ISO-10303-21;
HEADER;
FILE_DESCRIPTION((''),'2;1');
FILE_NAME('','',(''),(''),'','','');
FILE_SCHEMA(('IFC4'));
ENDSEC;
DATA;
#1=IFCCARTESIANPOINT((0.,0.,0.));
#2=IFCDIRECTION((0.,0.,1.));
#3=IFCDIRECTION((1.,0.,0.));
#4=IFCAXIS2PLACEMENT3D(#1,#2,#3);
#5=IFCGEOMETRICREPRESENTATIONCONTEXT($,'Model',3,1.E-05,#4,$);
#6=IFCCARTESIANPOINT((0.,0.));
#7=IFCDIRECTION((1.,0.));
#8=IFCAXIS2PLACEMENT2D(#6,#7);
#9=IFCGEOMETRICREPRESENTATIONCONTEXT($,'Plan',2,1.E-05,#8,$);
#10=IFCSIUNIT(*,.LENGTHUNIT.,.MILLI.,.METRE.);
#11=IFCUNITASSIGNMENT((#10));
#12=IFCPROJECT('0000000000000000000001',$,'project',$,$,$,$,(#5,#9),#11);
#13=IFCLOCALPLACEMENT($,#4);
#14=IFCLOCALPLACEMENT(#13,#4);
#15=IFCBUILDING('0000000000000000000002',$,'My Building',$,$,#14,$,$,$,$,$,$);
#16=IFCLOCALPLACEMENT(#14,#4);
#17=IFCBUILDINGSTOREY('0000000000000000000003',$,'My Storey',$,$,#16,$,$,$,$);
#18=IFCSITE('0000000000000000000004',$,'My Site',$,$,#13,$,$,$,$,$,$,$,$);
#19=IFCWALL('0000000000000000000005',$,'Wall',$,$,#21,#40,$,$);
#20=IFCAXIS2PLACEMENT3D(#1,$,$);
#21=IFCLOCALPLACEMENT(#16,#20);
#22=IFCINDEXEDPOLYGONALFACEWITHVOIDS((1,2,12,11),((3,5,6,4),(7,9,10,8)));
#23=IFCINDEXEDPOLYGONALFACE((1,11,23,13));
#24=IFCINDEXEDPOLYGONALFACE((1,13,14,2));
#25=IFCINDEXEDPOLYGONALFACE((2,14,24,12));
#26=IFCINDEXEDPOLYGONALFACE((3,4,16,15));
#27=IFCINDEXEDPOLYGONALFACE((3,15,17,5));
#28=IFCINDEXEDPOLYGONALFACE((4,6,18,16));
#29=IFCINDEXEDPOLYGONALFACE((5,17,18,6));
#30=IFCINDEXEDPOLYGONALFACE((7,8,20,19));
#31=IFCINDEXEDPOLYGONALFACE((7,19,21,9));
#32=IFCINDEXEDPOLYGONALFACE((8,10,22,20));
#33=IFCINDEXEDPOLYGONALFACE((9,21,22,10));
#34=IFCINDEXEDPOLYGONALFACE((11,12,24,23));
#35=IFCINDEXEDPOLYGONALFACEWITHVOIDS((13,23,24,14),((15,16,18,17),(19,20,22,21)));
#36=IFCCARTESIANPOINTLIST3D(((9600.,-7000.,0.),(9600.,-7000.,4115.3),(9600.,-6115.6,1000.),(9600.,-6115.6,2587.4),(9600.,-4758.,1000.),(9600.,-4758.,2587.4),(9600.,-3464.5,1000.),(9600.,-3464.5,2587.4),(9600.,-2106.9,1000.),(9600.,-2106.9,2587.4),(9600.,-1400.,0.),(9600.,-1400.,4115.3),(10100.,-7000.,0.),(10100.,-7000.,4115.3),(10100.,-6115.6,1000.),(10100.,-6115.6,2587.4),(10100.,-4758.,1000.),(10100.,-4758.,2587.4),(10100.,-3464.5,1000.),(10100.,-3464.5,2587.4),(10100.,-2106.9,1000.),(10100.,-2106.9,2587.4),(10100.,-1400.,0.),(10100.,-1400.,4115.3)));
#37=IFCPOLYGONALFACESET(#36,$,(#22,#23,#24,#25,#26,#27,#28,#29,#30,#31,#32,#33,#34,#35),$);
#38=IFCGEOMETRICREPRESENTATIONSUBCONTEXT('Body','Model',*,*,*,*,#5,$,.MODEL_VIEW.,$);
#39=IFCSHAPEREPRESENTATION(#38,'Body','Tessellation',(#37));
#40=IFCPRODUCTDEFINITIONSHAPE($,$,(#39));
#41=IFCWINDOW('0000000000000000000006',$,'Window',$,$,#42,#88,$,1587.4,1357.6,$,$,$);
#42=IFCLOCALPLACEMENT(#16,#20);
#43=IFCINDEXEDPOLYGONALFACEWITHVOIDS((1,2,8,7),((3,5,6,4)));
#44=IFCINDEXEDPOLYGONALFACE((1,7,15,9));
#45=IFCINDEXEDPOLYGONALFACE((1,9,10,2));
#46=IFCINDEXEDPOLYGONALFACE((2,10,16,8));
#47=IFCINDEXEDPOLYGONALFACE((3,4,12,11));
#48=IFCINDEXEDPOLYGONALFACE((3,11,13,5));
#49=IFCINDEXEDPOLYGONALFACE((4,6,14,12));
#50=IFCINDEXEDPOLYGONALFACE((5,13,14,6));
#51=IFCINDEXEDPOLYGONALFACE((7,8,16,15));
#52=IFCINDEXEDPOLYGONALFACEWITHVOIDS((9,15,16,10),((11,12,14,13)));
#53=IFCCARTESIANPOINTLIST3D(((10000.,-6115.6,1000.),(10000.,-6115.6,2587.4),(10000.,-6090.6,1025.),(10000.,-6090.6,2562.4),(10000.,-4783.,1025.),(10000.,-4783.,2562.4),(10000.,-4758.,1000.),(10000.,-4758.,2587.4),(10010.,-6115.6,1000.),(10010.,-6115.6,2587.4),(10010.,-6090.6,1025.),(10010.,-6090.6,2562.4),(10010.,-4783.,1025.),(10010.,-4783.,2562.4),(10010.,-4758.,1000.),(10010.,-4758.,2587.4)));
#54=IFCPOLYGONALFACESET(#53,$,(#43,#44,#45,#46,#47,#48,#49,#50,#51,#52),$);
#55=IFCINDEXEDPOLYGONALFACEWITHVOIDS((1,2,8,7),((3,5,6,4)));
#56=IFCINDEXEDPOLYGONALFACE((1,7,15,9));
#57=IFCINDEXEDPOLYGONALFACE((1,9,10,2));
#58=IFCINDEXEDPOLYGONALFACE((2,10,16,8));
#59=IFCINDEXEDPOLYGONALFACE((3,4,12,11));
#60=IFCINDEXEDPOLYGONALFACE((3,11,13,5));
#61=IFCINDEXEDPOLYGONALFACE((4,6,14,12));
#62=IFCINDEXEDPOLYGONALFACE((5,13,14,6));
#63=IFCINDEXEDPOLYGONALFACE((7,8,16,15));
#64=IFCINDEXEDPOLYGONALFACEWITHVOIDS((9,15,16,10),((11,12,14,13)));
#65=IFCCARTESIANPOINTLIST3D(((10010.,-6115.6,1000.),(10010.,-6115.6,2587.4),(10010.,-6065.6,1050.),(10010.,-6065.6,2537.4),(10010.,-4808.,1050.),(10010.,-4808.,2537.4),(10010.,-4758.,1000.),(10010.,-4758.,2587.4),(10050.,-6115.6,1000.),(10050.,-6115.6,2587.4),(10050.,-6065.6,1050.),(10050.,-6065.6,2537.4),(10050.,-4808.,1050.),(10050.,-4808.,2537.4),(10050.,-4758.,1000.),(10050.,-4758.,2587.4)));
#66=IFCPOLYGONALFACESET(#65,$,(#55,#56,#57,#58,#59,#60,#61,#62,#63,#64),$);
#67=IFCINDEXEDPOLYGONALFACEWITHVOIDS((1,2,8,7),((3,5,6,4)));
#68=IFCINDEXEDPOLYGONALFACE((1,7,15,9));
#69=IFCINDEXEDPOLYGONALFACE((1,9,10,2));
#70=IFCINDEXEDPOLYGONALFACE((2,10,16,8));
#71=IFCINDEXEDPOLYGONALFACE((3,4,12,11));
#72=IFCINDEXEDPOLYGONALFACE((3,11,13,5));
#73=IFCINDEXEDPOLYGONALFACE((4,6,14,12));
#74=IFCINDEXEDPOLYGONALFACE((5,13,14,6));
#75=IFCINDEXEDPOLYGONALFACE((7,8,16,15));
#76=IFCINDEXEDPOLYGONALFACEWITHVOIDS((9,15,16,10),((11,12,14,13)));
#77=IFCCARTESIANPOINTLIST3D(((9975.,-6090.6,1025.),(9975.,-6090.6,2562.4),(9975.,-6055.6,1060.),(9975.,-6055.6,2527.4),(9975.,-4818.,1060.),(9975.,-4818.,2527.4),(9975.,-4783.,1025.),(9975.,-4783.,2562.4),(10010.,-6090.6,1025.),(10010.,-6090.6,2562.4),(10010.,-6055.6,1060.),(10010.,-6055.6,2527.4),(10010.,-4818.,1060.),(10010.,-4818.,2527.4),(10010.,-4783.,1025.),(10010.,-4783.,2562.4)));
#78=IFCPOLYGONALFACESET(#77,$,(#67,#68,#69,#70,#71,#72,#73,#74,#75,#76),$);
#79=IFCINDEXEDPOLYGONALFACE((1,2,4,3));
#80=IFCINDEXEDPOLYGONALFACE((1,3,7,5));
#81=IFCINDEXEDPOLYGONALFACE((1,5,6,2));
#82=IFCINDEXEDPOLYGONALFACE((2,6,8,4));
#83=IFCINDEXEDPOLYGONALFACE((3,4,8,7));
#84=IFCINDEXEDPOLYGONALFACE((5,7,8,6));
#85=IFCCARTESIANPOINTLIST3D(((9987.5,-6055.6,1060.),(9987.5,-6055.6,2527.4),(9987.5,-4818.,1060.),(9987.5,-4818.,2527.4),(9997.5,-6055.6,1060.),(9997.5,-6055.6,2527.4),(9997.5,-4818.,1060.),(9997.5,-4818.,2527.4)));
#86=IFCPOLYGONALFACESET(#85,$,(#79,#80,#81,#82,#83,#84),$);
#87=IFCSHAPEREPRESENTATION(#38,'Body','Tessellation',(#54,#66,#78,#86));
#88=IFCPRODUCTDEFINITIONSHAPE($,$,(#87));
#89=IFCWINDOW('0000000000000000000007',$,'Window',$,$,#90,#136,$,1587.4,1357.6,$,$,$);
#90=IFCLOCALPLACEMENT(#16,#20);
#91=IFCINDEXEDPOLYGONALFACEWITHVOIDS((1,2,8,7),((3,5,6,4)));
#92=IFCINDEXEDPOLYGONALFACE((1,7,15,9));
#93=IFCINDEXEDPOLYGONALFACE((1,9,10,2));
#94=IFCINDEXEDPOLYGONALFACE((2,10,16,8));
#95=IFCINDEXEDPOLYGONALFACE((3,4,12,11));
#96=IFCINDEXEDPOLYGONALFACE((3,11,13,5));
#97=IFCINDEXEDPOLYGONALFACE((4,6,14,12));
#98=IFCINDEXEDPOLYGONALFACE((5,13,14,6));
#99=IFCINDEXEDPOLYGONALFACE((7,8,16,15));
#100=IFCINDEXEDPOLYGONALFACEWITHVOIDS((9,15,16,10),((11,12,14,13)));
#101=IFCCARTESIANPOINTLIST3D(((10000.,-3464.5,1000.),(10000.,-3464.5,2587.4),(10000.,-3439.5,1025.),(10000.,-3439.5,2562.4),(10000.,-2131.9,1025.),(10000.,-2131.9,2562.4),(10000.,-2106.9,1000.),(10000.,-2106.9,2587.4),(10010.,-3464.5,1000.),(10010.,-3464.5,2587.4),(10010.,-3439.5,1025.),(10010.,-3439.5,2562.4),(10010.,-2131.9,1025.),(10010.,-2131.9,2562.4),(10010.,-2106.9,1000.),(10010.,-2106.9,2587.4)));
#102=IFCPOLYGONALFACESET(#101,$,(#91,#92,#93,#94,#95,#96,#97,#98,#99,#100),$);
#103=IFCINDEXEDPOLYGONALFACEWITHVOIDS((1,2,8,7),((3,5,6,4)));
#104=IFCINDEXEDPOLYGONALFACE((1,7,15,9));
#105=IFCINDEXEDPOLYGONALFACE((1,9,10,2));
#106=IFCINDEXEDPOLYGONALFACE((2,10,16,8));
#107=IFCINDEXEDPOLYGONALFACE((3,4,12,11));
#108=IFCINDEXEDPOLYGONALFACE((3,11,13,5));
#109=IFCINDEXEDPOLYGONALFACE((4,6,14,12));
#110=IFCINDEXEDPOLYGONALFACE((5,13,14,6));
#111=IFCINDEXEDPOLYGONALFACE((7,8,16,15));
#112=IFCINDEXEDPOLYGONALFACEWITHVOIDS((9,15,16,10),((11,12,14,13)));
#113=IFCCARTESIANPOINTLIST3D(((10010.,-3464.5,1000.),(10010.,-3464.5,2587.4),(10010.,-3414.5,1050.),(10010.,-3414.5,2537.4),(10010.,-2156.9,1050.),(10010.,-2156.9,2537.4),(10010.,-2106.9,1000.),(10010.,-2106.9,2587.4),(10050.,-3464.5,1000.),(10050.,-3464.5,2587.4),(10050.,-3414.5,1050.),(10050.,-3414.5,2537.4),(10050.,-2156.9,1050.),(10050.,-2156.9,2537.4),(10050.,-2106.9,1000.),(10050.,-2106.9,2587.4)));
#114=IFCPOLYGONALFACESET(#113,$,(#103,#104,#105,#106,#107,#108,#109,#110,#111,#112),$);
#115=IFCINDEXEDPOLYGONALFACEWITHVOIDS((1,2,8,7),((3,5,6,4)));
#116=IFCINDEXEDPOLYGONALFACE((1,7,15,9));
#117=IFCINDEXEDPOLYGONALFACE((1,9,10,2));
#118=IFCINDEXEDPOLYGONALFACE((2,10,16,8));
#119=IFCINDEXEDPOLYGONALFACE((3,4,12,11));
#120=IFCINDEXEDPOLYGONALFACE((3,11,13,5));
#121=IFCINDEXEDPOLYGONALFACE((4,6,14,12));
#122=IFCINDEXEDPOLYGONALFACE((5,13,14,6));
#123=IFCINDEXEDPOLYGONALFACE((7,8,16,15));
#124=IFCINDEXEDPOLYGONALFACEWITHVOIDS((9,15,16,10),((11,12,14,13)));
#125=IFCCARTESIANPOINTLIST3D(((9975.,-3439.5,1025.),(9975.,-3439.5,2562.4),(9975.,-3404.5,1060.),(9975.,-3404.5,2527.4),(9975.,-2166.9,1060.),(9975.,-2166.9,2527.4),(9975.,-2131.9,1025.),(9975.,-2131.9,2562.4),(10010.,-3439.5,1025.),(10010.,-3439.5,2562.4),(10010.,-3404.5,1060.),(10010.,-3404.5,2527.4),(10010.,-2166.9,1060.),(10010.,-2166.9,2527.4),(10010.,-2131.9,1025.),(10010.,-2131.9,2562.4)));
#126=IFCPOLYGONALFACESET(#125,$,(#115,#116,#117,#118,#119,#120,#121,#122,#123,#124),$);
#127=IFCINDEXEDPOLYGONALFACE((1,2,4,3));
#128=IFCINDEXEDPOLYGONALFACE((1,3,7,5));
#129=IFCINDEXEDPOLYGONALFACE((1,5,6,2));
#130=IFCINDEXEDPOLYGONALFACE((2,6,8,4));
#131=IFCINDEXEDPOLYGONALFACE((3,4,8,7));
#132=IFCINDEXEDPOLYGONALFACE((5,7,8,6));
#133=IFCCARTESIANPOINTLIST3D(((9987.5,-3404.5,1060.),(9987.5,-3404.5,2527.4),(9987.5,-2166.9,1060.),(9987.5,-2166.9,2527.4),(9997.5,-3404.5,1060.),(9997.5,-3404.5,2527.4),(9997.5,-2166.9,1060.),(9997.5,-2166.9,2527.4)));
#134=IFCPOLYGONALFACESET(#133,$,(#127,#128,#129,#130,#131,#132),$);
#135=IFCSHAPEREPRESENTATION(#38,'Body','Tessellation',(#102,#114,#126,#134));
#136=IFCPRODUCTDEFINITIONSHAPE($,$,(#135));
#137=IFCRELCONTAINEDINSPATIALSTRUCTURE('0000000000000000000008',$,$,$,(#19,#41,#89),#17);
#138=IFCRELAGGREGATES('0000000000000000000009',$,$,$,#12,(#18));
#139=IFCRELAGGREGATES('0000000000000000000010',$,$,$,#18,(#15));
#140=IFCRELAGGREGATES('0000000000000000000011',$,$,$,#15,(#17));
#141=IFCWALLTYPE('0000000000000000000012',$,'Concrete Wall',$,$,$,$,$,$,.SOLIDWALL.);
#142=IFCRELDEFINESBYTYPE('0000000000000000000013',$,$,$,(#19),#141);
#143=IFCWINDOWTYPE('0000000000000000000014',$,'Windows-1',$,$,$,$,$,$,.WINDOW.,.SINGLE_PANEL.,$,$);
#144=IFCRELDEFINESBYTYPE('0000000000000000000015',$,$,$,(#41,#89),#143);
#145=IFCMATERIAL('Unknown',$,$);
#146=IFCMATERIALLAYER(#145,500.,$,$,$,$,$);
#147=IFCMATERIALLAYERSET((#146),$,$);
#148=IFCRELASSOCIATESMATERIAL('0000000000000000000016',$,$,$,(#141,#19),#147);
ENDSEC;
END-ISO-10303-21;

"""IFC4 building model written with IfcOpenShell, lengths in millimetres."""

from ifc_helpers import new_model, entity, si_unit, frame, origin_with_axes, origin_2d_with_axis, place, context, subcontext, project, spatial, line, indexed_curve, outline, extrude, shape, source, transform, mapped, material, layer, layer_set, layer_usage, type_object, type_shapes, element, fill, save


model = new_model("IFC4")

# Units and contexts
model_context = context("Model", 3, precision=1e-05, world=origin_with_axes())
plan_context = context("Plan", 2, precision=1e-05, world=origin_2d_with_axis())
body_context_1 = subcontext(model_context, "Body", "Model", "MODEL_VIEW")
body_context_2 = subcontext(plan_context, "Body", "Plan", "PLAN_VIEW")
ifc_project = project(units=[si_unit("LENGTHUNIT", "METRE", prefix="MILLI")], contexts=[model_context, plan_context])

# Site, building, storey
site_placement = place(None, origin_with_axes())
site = spatial("IfcSite", under=ifc_project, at=site_placement, Name="My Site")
building_placement = place(site_placement, origin_with_axes())
building = spatial("IfcBuilding", under=site, at=building_placement, Name="My Building")
storey_placement = place(building_placement, origin_with_axes())
storey = spatial("IfcBuildingStorey", under=building, at=storey_placement, Name="My Storey")

# Shared definitions
ifc_material = material(Name="Unknown")

# Wall, openings, windows
ifc_layer_1 = layer(ifc_material, 500.0)
ifc_layer_set_1 = layer_set([ifc_layer_1])
wall_type = type_object("IfcWallType", Name="Concrete Wall", PredefinedType="SOLIDWALL", material=ifc_layer_set_1)
shared_shape_1 = source(origin_with_axes(), body_context_1, "Body", "SweptSolid", [
    extrude(outline(indexed_curve([(0.0, 0.0), (1357.6, 0.0), (1357.6, 1587.4), (0.0, 1587.4)], segments=[line(1, 2, 3, 4, 1)])), frame((0.0, -600.0, 0.0), z_axis=(0.0, -1.0, 0.0), x_axis=(1.0, 0.0, 0.0)), (0.0, 0.0, -1.0), 1200.0),
])
window_type = type_object("IfcWindowType", Name="Windows-1", PartitioningType="SINGLE_PANEL", PredefinedType="WINDOW")
shared_shape_2 = source(origin_with_axes(), body_context_1, "Body", "SweptSolid", [
    extrude(outline(indexed_curve([(0.0, 0.0), (1357.6, 0.0), (1357.6, 1587.4), (0.0, 1587.4)], segments=[line(1, 2, 3, 4, 1)]), holes=[indexed_curve([(25.0, 25.0), (1332.6, 25.0), (1332.6, 1562.4), (25.0, 1562.4)], segments=[line(1, 2, 3, 4, 1)])]), frame((0.0, 90.0, 0.0), z_axis=(0.0, -1.0, 0.0), x_axis=(1.0, 0.0, 0.0)), (0.0, 0.0, -1.0), 10.0),
    extrude(outline(indexed_curve([(0.0, 0.0), (1357.6, 0.0), (1357.6, 1587.4), (0.0, 1587.4)], segments=[line(1, 2, 3, 4, 1)]), holes=[indexed_curve([(50.0, 50.0), (1307.6, 50.0), (1307.6, 1537.4), (50.0, 1537.4)], segments=[line(1, 2, 3, 4, 1)])]), frame((0.0, 50.0, 0.0), z_axis=(0.0, -1.0, 0.0), x_axis=(1.0, 0.0, 0.0)), (0.0, 0.0, -1.0), 40.0),
    extrude(outline(indexed_curve([(0.0, 0.0), (1307.6, 0.0), (1307.6, 1537.4), (0.0, 1537.4)], segments=[line(1, 2, 3, 4, 1)]), holes=[indexed_curve([(35.0, 35.0), (1272.6, 35.0), (1272.6, 1502.4), (35.0, 1502.4)], segments=[line(1, 2, 3, 4, 1)])]), frame((25.0, 90.0, 25.0), z_axis=(0.0, -1.0, 0.0), x_axis=(1.0, 0.0, 0.0)), (0.0, 0.0, -1.0), 35.0),
    extrude(outline(indexed_curve([(35.0, 35.0), (1272.6, 35.0), (1272.6, 1502.4), (35.0, 1502.4)], segments=[line(1, 2, 3, 4, 1)])), frame((25.0, 102.5, 25.0), z_axis=(0.0, -1.0, 0.0), x_axis=(1.0, 0.0, 0.0)), (0.0, 0.0, -1.0), 10.0),
])
shared_shape_3 = source(origin_with_axes(), body_context_2, "Body", "Curve2D", [
    entity("IfcIndexedPolyCurve", entity("IfcCartesianPointList2D", [[50.0, 50.0], [1307.6, 50.0]])),
    entity("IfcIndexedPolyCurve", entity("IfcCartesianPointList2D", [[0.0, 100.0], [25.0, 100.0], [25.0, 90.0], [50.0, 90.0], [50.0, 50.0], [0.0, 50.0]]), [entity("IfcLineIndex", [1, 2, 3, 4, 5, 6, 1])]),
    entity("IfcIndexedPolyCurve", entity("IfcCartesianPointList2D", [[1357.6, 100.0], [1332.6, 100.0], [1332.6, 90.0], [1307.6, 90.0], [1307.6, 50.0], [1357.6, 50.0]]), [entity("IfcLineIndex", [1, 2, 3, 4, 5, 6, 1])]),
    entity("IfcIndexedPolyCurve", entity("IfcCartesianPointList2D", [[25.0, 90.0], [60.0, 90.0], [60.0, 125.0], [25.0, 125.0]]), [entity("IfcLineIndex", [1, 2, 3, 4, 1])]),
    entity("IfcIndexedPolyCurve", entity("IfcCartesianPointList2D", [[1332.6, 90.0], [1297.6, 90.0], [1297.6, 125.0], [1332.6, 125.0]]), [entity("IfcLineIndex", [1, 2, 3, 4, 1])]),
    entity("IfcIndexedPolyCurve", entity("IfcCartesianPointList2D", [[60.0, 90.0], [1297.6, 90.0]])),
    entity("IfcIndexedPolyCurve", entity("IfcCartesianPointList2D", [[60.0, 125.0], [1297.6, 125.0]])),
    entity("IfcIndexedPolyCurve", entity("IfcCartesianPointList2D", [[60.0, 107.5], [1297.6, 107.5]])),
])
type_shapes(window_type, [shared_shape_2, shared_shape_3])
ifc_layer_usage_1 = layer_usage(ifc_layer_set_1, "AXIS2", "POSITIVE", 0.0)
wall_1_placement = place(storey_placement, frame((9600.0, -1400.0, 0.0), z_axis=(0.0, 0.0, 1.0), x_axis=(0.0, -1.0, 0.0)))
wall_1 = element("IfcWall", 1, at=wall_1_placement, inside=storey, type_object=wall_type, material=ifc_layer_usage_1, Name="Wall", context=body_context_1, shape_type="SweptSolid", body=[
    extrude(outline(indexed_curve([(0.0, 0.0), (0.0, 500.0), (5600.0, 500.0), (5600.0, 0.0)], segments=[line(1, 2, 3, 4, 1)])), origin_with_axes(), (0.0, 0.0, 1.0), 4115.3),
])
opening_1_placement = place(wall_1_placement, frame((4715.6, 500.0, 1000.0), z_axis=(0.0, 0.0, 1.0), x_axis=(-1.0, 0.0, 0.0)))
opening_1 = element("IfcOpeningElement", 2, at=opening_1_placement, cuts=wall_1, PredefinedType="OPENING", context=body_context_1, shape_type="MappedRepresentation", body=[
    mapped(shared_shape_1, transform((0.0, 0.0, 0.0), x_axis=(1.0, 0.0, 0.0), y_axis=(0.0, 1.0, 0.0), z_axis=(0.0, 0.0, 1.0), scale=1.0)),
])
opening_2_placement = place(wall_1_placement, frame((2064.5, 500.0, 1000.0), z_axis=(0.0, 0.0, 1.0), x_axis=(-1.0, 0.0, 0.0)))
opening_2 = element("IfcOpeningElement", 3, at=opening_2_placement, cuts=wall_1, PredefinedType="OPENING", context=body_context_1, shape_type="MappedRepresentation", body=[
    mapped(shared_shape_1, transform((0.0, 0.0, 0.0), x_axis=(1.0, 0.0, 0.0), y_axis=(0.0, 1.0, 0.0), z_axis=(0.0, 0.0, 1.0), scale=1.0)),
])
window_1_placement = place(opening_1_placement, frame((0.0, 0.0, 0.0), z_axis=(0.0, 0.0, 1.0), x_axis=(1.0, 0.0, 0.0)))
window_1 = element("IfcWindow", 4, at=window_1_placement, inside=storey, type_object=window_type, Name="Window", OverallHeight=1587.4, OverallWidth=1357.6, shapes=[
    shape(body_context_1, "Body", "MappedRepresentation", [mapped(shared_shape_2, transform((0.0, 0.0, 0.0), x_axis=(1.0, 0.0, 0.0), y_axis=(0.0, 1.0, 0.0), z_axis=(0.0, 0.0, 1.0), scale=1.0))]),
    shape(body_context_2, "Body", "MappedRepresentation", [mapped(shared_shape_3, transform((0.0, 0.0, 0.0), x_axis=(1.0, 0.0, 0.0), y_axis=(0.0, 1.0, 0.0), z_axis=(0.0, 0.0, 1.0), scale=1.0))]),
])
fill(opening_1, window_1)
window_2_placement = place(opening_2_placement, frame((0.0, 0.0, 0.0), z_axis=(0.0, 0.0, 1.0), x_axis=(1.0, 0.0, 0.0)))
window_2 = element("IfcWindow", 5, at=window_2_placement, inside=storey, type_object=window_type, Name="Window", OverallHeight=1587.4, OverallWidth=1357.6, shapes=[
    shape(body_context_1, "Body", "MappedRepresentation", [mapped(shared_shape_2, transform((0.0, 0.0, 0.0), x_axis=(1.0, 0.0, 0.0), y_axis=(0.0, 1.0, 0.0), z_axis=(0.0, 0.0, 1.0), scale=1.0))]),
    shape(body_context_2, "Body", "MappedRepresentation", [mapped(shared_shape_3, transform((0.0, 0.0, 0.0), x_axis=(1.0, 0.0, 0.0), y_axis=(0.0, 1.0, 0.0), z_axis=(0.0, 0.0, 1.0), scale=1.0))]),
])
fill(opening_2, window_2)

save(model, "model.ifc")
